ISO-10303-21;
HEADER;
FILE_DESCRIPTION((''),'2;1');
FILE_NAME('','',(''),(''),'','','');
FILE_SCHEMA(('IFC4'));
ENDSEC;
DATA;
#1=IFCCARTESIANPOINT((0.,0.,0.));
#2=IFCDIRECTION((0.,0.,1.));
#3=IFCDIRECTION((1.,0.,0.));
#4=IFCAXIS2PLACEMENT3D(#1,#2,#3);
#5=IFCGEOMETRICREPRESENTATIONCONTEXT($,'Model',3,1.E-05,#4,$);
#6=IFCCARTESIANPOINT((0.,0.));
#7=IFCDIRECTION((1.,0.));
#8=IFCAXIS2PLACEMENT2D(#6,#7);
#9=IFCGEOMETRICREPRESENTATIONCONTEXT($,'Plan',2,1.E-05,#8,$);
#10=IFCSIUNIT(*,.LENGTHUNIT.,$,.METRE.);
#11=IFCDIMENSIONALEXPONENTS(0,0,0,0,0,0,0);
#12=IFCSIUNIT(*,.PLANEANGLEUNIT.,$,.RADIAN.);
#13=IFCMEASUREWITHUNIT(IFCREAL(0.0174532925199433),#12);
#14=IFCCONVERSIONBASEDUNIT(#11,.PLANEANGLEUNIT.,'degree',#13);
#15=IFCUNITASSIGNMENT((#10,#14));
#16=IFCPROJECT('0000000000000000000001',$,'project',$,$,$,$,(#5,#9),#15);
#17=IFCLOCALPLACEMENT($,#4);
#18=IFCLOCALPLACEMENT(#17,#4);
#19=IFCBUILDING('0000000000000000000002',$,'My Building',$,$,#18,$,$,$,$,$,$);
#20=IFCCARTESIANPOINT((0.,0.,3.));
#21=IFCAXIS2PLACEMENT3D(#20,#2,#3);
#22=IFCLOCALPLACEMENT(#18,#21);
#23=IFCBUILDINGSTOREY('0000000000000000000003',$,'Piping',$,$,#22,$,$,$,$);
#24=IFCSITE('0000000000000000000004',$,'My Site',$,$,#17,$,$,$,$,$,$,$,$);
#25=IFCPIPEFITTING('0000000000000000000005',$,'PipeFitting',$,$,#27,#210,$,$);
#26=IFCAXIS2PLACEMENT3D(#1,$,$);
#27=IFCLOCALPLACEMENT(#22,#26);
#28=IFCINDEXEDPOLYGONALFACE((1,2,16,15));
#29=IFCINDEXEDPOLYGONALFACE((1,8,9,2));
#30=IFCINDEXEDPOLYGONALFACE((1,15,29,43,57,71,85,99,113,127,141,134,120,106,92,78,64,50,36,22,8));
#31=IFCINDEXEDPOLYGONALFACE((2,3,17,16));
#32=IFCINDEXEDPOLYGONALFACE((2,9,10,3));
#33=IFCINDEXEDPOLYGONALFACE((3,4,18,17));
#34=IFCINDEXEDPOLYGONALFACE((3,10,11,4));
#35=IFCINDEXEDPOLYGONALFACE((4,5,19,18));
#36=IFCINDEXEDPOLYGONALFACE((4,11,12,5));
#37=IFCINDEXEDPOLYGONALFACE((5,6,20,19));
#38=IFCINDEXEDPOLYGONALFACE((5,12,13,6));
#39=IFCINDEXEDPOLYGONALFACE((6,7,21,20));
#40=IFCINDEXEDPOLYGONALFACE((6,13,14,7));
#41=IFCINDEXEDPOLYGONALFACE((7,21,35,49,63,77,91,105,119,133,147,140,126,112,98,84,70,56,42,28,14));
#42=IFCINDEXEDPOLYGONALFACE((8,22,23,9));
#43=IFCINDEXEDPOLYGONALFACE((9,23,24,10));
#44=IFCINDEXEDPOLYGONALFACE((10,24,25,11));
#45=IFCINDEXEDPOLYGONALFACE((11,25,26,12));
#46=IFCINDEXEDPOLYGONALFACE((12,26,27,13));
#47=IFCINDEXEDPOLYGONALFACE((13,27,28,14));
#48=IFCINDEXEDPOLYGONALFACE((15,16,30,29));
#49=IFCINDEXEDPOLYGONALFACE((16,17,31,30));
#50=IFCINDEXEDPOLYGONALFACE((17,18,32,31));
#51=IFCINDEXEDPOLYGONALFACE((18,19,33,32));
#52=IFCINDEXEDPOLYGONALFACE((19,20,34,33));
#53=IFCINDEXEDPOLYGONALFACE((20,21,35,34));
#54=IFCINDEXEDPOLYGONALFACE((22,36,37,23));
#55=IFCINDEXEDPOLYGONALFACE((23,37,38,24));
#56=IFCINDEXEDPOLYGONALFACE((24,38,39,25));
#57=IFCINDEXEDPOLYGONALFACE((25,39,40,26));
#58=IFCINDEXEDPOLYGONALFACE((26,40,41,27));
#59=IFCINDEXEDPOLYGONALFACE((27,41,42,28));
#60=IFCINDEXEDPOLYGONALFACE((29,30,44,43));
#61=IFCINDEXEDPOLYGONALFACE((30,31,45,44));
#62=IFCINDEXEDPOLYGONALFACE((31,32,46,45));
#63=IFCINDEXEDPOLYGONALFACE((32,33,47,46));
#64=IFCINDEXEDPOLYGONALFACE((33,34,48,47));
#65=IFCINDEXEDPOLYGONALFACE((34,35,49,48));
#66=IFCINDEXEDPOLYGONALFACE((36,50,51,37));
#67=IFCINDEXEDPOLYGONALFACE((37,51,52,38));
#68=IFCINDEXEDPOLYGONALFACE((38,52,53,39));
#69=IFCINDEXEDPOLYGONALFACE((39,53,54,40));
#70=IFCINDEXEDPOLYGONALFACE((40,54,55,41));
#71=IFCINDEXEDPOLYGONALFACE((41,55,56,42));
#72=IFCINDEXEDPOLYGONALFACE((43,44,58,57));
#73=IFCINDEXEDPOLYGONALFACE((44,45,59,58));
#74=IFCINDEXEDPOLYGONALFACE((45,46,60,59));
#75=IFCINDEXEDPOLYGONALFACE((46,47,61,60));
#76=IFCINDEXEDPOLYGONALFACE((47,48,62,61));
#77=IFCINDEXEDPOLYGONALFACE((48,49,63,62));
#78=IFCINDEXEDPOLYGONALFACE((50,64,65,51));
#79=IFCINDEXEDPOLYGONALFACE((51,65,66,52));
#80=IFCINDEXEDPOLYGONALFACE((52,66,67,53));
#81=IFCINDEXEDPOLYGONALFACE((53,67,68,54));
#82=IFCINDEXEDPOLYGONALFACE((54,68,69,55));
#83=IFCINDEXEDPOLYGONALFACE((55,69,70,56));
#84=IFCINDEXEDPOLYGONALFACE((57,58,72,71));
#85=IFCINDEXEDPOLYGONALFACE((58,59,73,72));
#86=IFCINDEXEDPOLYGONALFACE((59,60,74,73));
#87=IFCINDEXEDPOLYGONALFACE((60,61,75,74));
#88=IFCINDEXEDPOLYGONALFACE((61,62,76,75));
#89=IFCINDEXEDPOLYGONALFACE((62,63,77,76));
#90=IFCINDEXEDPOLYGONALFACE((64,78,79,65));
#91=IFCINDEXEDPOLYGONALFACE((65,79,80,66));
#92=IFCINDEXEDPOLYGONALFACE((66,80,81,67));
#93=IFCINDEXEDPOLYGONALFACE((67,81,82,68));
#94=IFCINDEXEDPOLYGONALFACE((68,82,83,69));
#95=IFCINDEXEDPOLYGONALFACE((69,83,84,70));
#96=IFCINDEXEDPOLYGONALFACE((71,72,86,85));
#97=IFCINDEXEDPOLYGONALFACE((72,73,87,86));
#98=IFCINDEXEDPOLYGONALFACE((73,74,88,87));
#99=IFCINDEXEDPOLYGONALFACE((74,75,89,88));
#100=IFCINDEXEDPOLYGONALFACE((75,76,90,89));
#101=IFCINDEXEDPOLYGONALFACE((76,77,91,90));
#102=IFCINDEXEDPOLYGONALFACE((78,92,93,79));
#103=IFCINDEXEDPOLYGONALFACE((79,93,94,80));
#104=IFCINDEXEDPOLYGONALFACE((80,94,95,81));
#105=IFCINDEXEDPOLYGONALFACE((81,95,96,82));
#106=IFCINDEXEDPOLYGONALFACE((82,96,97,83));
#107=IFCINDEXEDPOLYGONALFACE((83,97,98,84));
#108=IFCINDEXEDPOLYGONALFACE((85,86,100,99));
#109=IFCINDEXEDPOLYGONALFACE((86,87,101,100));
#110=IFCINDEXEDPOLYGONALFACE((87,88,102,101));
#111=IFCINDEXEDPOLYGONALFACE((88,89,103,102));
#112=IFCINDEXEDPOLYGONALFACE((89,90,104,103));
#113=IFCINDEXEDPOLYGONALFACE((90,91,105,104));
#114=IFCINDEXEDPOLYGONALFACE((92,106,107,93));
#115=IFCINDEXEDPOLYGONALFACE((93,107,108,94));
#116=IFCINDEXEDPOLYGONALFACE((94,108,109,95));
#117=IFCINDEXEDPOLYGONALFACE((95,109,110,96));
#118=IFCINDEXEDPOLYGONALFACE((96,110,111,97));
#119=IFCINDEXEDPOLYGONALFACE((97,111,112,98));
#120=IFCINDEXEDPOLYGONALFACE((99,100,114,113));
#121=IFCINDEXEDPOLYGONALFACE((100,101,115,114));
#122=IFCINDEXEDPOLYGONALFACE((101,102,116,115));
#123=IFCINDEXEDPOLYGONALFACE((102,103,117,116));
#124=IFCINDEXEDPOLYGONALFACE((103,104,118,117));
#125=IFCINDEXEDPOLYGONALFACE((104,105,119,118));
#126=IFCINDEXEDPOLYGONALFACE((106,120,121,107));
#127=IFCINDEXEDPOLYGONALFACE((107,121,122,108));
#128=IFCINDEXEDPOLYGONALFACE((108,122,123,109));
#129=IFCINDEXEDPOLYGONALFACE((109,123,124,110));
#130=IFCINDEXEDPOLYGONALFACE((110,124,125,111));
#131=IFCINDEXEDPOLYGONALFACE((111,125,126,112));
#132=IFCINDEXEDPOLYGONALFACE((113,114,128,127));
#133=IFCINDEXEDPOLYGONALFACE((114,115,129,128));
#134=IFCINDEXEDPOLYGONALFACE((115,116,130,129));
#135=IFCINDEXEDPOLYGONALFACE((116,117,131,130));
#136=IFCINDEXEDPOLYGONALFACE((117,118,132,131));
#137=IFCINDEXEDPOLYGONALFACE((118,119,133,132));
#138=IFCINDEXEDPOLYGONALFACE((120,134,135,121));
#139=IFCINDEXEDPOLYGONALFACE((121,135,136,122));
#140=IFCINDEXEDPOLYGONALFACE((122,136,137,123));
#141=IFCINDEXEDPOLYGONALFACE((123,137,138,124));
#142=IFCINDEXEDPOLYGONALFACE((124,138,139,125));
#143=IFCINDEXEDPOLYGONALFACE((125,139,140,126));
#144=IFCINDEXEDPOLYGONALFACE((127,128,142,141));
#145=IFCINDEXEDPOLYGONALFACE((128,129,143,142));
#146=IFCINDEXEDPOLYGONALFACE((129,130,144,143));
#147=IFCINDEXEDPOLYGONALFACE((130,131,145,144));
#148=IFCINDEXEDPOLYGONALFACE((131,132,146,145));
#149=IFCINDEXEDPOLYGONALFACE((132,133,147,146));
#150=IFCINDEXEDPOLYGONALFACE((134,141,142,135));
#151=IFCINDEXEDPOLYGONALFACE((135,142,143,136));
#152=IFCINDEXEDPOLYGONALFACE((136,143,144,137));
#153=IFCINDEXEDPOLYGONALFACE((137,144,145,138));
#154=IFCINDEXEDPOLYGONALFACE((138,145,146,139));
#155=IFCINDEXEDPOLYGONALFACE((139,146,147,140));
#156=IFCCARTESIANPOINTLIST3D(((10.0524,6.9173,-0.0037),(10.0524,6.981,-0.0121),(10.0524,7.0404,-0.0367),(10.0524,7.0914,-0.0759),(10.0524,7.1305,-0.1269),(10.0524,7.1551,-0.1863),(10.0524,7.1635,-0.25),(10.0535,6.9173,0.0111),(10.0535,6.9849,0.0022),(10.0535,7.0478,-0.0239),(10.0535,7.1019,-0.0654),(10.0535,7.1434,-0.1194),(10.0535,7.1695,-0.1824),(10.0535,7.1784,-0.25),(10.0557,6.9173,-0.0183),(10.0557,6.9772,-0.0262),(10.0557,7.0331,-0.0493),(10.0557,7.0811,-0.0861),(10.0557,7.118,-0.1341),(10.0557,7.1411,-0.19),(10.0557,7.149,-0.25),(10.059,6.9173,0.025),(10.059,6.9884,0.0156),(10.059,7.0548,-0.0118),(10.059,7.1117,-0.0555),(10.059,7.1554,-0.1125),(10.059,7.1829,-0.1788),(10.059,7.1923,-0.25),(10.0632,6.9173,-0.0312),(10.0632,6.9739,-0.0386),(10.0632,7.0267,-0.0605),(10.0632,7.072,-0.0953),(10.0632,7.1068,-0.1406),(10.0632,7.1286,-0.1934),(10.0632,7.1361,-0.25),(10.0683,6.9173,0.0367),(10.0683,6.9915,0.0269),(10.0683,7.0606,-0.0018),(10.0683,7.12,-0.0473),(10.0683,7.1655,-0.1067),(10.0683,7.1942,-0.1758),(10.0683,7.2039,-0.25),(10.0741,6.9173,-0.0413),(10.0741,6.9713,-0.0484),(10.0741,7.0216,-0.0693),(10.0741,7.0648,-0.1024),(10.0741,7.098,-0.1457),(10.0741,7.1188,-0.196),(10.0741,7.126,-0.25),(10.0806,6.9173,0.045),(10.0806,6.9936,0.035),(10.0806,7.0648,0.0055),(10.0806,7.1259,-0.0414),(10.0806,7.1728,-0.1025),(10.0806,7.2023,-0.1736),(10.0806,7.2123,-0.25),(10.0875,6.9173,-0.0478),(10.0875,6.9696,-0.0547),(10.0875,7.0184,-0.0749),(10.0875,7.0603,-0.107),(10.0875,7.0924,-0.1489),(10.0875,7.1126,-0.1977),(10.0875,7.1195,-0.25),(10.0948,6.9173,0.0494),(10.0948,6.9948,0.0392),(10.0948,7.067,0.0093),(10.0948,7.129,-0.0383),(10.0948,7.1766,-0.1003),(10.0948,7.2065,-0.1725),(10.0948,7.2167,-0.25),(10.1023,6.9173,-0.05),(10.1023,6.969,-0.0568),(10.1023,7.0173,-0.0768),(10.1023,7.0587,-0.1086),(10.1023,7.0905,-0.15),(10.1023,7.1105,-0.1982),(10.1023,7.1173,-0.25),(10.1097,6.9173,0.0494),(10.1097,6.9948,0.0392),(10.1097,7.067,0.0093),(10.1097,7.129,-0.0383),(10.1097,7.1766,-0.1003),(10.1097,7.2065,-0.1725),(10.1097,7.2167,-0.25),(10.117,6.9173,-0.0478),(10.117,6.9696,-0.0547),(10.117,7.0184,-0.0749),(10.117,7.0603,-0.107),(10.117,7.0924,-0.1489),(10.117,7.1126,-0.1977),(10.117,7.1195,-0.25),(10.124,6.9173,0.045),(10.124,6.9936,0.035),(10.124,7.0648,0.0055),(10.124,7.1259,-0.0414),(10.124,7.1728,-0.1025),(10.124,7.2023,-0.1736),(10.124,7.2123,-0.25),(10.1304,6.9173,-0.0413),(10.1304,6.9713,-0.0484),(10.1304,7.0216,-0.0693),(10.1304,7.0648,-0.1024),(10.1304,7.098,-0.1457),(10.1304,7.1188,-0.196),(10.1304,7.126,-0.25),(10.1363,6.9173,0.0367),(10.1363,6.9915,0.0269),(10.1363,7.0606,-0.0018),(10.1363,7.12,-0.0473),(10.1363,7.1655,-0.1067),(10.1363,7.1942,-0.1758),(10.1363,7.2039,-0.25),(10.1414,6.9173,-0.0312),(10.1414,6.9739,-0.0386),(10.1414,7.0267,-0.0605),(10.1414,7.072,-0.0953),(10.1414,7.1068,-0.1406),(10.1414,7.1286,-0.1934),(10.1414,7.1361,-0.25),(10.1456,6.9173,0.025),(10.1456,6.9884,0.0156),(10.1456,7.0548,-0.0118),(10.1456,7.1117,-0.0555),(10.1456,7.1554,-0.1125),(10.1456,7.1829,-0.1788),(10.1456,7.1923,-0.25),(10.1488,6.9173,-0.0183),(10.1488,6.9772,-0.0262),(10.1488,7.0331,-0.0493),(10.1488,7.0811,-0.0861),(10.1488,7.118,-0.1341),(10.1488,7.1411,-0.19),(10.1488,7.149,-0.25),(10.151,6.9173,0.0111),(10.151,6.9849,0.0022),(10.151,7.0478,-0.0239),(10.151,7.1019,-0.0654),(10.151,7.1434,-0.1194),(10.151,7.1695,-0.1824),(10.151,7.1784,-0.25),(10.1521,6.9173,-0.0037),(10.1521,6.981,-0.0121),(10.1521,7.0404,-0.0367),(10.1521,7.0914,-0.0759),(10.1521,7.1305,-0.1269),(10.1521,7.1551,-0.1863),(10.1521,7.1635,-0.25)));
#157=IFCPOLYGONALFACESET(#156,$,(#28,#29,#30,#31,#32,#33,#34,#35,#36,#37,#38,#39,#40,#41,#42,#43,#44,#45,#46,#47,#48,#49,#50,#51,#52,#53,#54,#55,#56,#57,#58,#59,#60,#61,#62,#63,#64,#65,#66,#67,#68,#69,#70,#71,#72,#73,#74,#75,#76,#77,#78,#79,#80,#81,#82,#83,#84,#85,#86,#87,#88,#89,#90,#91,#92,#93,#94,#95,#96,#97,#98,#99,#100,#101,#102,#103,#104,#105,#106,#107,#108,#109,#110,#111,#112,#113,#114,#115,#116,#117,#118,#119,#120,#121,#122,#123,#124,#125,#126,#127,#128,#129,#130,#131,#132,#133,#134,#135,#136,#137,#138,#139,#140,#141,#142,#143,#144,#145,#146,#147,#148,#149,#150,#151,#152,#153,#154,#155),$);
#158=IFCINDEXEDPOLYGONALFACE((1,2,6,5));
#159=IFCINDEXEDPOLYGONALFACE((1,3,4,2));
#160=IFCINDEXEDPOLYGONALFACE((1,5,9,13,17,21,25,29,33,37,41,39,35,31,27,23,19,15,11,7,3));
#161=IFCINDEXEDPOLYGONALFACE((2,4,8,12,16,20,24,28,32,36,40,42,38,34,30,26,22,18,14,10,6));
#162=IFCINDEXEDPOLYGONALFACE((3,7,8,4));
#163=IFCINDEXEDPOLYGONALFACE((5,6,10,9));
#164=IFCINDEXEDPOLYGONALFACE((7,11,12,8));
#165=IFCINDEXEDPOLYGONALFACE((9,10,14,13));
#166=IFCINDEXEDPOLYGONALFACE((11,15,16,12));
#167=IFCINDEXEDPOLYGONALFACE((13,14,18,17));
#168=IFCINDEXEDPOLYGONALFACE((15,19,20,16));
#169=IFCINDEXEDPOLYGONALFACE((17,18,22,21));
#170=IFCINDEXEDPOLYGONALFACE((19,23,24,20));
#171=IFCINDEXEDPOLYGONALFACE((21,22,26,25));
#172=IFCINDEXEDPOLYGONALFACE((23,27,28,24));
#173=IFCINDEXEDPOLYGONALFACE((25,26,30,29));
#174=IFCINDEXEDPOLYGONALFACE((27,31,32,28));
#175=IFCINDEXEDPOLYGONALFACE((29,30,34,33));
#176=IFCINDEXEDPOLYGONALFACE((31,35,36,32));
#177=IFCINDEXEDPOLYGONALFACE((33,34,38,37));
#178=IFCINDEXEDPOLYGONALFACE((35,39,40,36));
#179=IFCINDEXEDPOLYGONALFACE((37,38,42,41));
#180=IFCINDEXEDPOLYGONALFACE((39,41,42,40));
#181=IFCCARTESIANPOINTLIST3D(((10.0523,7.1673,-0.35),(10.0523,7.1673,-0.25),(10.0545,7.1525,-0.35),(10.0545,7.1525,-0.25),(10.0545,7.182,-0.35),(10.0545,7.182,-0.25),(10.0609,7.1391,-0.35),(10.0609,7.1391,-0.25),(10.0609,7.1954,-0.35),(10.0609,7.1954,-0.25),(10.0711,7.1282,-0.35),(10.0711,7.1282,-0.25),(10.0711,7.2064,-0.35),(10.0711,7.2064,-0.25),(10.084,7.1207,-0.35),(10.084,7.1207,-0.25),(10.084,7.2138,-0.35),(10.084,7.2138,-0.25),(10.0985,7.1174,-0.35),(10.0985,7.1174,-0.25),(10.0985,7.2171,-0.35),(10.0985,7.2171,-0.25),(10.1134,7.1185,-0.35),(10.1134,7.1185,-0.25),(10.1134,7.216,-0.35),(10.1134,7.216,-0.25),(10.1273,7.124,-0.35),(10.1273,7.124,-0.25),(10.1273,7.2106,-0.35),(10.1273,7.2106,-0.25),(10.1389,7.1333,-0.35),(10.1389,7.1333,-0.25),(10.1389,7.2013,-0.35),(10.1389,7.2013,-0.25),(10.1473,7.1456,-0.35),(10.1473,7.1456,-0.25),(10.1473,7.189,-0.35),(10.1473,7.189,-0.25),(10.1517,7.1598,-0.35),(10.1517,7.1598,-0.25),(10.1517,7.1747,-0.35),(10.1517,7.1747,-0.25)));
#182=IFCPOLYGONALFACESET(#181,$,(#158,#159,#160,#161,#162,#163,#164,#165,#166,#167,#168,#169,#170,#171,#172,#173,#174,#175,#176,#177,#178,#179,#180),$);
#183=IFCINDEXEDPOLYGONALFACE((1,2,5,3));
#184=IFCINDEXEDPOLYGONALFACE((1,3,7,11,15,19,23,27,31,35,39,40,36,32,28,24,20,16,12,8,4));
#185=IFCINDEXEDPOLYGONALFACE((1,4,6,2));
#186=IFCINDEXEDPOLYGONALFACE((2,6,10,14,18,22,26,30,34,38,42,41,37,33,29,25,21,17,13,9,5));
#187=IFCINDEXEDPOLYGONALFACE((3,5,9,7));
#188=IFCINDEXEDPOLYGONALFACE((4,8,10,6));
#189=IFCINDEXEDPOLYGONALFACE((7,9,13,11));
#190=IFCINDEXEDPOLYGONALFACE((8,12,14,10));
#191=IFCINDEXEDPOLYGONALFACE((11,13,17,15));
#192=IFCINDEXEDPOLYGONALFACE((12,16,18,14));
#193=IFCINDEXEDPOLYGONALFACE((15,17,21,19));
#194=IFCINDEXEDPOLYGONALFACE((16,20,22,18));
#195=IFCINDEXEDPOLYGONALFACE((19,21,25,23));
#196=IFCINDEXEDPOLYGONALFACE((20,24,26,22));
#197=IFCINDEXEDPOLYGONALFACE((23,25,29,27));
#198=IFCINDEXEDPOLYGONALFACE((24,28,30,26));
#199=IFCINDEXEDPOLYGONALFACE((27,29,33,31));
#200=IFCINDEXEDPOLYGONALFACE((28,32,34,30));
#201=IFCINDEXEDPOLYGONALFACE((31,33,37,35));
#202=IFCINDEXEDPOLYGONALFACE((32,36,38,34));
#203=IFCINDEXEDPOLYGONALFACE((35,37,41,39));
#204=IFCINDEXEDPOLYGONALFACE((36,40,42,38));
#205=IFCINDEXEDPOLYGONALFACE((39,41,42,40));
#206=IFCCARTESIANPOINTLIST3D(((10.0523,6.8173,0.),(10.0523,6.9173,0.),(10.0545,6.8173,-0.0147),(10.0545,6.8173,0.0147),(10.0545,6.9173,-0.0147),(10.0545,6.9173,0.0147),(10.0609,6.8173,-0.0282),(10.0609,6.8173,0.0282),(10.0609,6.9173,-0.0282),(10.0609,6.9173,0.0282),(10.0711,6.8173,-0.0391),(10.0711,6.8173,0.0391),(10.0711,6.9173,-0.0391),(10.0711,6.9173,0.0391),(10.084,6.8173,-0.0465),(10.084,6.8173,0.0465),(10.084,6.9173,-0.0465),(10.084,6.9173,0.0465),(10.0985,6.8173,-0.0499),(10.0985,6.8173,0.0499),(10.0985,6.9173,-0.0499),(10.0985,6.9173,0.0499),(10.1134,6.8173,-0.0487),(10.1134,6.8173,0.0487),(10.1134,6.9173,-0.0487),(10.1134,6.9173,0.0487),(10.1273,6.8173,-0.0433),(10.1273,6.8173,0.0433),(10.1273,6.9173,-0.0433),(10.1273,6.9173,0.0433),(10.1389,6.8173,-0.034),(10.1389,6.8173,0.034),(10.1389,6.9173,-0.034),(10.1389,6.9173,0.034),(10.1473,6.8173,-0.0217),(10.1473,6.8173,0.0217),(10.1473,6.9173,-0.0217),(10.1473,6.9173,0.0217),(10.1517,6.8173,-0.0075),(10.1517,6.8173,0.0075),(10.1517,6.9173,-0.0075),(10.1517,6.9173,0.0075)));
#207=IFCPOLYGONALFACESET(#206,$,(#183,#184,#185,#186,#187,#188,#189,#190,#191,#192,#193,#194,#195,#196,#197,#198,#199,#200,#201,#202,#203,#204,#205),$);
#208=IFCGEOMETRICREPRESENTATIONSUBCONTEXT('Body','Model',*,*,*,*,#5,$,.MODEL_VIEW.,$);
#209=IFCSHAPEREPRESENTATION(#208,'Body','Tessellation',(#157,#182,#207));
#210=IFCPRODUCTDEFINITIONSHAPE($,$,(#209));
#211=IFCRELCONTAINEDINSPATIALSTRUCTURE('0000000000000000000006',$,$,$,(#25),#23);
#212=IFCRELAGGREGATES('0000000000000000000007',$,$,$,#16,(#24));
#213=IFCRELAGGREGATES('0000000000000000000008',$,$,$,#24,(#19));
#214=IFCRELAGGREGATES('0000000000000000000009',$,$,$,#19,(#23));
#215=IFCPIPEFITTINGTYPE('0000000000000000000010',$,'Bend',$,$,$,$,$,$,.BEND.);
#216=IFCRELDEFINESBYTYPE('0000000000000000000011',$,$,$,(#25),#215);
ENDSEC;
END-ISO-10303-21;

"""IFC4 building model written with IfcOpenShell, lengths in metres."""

from ifc_helpers import new_model, entity, si_unit, converted_unit, frame, origin_with_axes, origin_2d_with_axis, place, context, subcontext, project, spatial, circle, extrude, source, transform, mapped, type_object, type_shapes, element, save


model = new_model("IFC4")

# Units and contexts
model_context = context("Model", 3, precision=1e-05, world=origin_with_axes())
plan_context = context("Plan", 2, precision=1e-05, world=origin_2d_with_axis())
body_context = subcontext(model_context, "Body", "Model", "MODEL_VIEW")
ifc_project = project(units=[si_unit("LENGTHUNIT", "METRE"), converted_unit("PLANEANGLEUNIT", "degree", entity("IfcReal", 0.0174532925199433), si_unit("PLANEANGLEUNIT", "RADIAN"), dimensions=[0, 0, 0, 0, 0, 0, 0])], contexts=[model_context, plan_context])

# Site, building, storey
site_placement = place(None, origin_with_axes())
site = spatial("IfcSite", under=ifc_project, at=site_placement, Name="My Site")
building_placement = place(site_placement, origin_with_axes())
building = spatial("IfcBuilding", under=site, at=building_placement, Name="My Building")
storey_placement = place(building_placement, frame((0.0, 0.0, 3.0), z_axis=(0.0, 0.0, 1.0), x_axis=(1.0, 0.0, 0.0)))
storey = spatial("IfcBuildingStorey", under=building, at=storey_placement, Name="Piping")

# Pipe fitting
pipe_fitting_type = type_object("IfcPipeFittingType", Name="Bend", PredefinedType="BEND")
shared_shape = source(origin_with_axes(), body_context, "Body", "SolidModel", [
    entity("IfcSweptDiskSolid", entity("IfcIndexedPolyCurve", entity("IfcCartesianPointList3D", [[0.0, 0.0, -0.1], [0.0, -0.0732, -0.2768], [0.0, -0.25, -0.35]]), [entity("IfcArcIndex", [1, 2, 3])]), 0.05),
    extrude(circle(Radius=0.05), origin_with_axes(), (0.0, 0.0, -1.0), 0.1),
    extrude(circle(Radius=0.05), frame((0.0, -0.25, -0.35), z_axis=(0.0, -1.0, 0.0), x_axis=(1.0, 0.0, 0.0)), (0.0, 0.0, 1.0), 0.1),
])
type_shapes(pipe_fitting_type, [shared_shape])
for number, where, z_axis, x_axis, name in (
    (1, (10.1023, 7.1673, -0.35), (0.0, 0.0, -1.0), (-1.0, 0.0, 0.0), "PipeFitting"),
):
    element("IfcPipeFitting", number, at=place(storey_placement, frame(where, z_axis=z_axis, x_axis=x_axis)), inside=storey, type_object=pipe_fitting_type, Name=name, context=body_context, shape_type="MappedRepresentation", body=[
        mapped(shared_shape, transform((0.0, 0.0, 0.0), x_axis=(1.0, 0.0, 0.0), y_axis=(0.0, 1.0, 0.0), z_axis=(0.0, 0.0, 1.0), scale=1.0)),
    ])

save(model, "model.ifc")
